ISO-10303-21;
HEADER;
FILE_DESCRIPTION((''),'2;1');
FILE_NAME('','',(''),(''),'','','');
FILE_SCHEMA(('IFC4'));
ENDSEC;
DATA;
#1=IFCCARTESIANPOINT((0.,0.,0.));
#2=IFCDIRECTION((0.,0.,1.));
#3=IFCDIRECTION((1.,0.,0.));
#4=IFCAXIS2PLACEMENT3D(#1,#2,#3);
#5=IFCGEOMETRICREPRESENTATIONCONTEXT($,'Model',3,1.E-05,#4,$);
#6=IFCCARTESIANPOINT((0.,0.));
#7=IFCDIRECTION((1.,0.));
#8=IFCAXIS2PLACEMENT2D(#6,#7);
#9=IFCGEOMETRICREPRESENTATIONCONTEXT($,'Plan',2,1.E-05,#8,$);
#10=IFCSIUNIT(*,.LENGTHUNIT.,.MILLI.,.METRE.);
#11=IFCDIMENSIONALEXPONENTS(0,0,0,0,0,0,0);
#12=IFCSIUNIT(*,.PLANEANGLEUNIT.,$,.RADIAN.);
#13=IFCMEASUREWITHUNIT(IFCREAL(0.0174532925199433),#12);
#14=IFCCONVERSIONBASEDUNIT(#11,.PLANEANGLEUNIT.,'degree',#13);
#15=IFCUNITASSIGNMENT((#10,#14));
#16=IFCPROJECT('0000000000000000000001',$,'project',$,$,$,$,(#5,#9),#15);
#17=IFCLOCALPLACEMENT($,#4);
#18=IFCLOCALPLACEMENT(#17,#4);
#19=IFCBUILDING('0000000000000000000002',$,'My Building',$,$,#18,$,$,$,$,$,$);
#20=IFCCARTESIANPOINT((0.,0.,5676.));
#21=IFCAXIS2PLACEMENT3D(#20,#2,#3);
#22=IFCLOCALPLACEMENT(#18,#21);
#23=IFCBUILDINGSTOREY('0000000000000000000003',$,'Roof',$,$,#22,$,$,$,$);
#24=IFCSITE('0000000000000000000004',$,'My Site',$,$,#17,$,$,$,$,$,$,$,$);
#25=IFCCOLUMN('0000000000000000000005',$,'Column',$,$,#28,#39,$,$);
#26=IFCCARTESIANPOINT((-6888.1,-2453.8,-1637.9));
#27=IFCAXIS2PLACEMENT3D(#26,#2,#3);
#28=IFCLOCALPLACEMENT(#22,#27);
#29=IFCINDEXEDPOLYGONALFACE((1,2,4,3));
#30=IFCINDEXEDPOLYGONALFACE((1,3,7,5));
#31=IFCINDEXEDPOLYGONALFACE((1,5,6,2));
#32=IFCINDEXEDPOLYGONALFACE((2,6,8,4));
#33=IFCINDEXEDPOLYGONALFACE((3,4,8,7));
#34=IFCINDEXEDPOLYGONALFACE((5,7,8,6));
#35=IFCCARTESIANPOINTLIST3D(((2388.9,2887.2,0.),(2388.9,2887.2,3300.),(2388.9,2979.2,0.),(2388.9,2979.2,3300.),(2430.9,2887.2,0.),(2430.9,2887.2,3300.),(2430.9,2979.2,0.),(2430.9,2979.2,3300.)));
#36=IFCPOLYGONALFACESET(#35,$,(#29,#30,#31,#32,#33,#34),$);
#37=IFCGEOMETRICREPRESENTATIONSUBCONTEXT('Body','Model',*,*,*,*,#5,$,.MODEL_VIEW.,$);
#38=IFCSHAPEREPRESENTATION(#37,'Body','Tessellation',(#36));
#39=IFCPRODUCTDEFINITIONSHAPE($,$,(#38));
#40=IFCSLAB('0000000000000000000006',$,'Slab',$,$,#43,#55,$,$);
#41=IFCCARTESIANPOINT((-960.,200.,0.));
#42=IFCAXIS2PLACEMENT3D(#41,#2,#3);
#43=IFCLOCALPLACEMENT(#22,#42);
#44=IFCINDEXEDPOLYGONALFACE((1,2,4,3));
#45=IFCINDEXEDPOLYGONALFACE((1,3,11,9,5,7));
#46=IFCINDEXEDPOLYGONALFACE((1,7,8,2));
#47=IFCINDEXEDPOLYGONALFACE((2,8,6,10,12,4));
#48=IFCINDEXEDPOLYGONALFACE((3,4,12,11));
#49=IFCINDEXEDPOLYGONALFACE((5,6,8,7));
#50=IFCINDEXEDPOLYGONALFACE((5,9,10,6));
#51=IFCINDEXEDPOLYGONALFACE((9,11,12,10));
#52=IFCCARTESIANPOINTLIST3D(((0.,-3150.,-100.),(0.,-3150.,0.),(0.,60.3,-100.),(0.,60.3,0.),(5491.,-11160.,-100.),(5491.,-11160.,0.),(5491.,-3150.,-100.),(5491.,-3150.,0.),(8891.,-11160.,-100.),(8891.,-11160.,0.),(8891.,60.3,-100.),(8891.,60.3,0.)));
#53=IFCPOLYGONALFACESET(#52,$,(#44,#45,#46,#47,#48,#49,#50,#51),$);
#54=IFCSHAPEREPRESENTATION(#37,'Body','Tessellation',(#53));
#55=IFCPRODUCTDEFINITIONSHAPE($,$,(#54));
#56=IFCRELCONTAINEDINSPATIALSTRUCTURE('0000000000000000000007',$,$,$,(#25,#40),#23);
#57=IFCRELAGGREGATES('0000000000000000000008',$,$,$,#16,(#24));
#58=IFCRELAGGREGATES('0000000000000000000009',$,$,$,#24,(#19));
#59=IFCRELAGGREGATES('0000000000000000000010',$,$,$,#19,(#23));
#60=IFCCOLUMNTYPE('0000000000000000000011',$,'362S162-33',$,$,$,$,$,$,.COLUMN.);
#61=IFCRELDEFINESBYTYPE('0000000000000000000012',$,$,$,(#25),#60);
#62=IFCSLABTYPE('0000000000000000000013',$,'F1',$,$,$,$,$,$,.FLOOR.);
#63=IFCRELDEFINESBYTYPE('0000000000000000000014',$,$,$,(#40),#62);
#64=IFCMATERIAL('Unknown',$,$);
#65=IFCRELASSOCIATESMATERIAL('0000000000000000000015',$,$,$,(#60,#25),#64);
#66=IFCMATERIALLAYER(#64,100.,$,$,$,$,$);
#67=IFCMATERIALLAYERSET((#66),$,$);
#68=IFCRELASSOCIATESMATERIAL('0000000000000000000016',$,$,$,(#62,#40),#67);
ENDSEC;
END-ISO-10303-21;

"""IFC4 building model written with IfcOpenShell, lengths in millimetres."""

from ifc_helpers import new_model, entity, si_unit, converted_unit, frame, origin_with_axes, origin_2d_with_axis, place, context, subcontext, project, spatial, indexed_curve, outline, extrude, material, layer, layer_set, layer_usage, material_profile, profile_set, profile_usage, type_object, element, save


model = new_model("IFC4")

# Units and contexts
model_context = context("Model", 3, precision=1e-05, world=origin_with_axes())
plan_context = context("Plan", 2, precision=1e-05, world=origin_2d_with_axis())
body_context = subcontext(model_context, "Body", "Model", "MODEL_VIEW")
ifc_project = project(units=[si_unit("LENGTHUNIT", "METRE", prefix="MILLI"), converted_unit("PLANEANGLEUNIT", "degree", entity("IfcReal", 0.0174532925199433), si_unit("PLANEANGLEUNIT", "RADIAN"), dimensions=[0, 0, 0, 0, 0, 0, 0])], contexts=[model_context, plan_context])

# Site, building, storey
site_placement = place(None, origin_with_axes())
site = spatial("IfcSite", under=ifc_project, at=site_placement, Name="My Site")
building_placement = place(site_placement, origin_with_axes())
building = spatial("IfcBuilding", under=site, at=building_placement, Name="My Building")
storey_placement = place(building_placement, frame((0.0, 0.0, 5676.0), z_axis=(0.0, 0.0, 1.0), x_axis=(1.0, 0.0, 0.0)))
storey = spatial("IfcBuildingStorey", under=building, at=storey_placement, Name="Roof")

# Column
ifc_material = material(Name="Unknown")
ifc_material_profile_1 = material_profile(ifc_material, outline(indexed_curve([(2430.9, 2887.2), (2388.9, 2887.2), (2388.9, 2979.2), (2430.9, 2979.2)])))
ifc_profile_set_1 = profile_set([ifc_material_profile_1])
ifc_profile_usage_1 = profile_usage(ifc_profile_set_1, cardinal=5)
column_type = type_object("IfcColumnType", Name="362S162-33", PredefinedType="COLUMN", material=ifc_profile_set_1)
column_placement = place(storey_placement, frame((-6888.1, -2453.8, -1637.9), z_axis=(0.0, 0.0, 1.0), x_axis=(1.0, 0.0, 0.0)))
element("IfcColumn", 1, at=column_placement, inside=storey, type_object=column_type, material=ifc_profile_usage_1, Name="Column", context=body_context, shape_type="SweptSolid", body=[
    extrude(outline(indexed_curve([(2430.9, 2887.2), (2388.9, 2887.2), (2388.9, 2979.2), (2430.9, 2979.2)])), origin_with_axes(), (0.0, 0.0, 1.0), 3300.0),
])

# Slab
ifc_layer = layer(ifc_material, 100.0)
ifc_layer_set = layer_set([ifc_layer])
ifc_layer_usage = layer_usage(ifc_layer_set, "AXIS3", "POSITIVE", -100.0)
slab_type = type_object("IfcSlabType", Name="F1", PredefinedType="FLOOR", material=ifc_layer_set)
slab_placement = place(storey_placement, frame((-960.0, 200.0, 0.0), z_axis=(0.0, 0.0, 1.0), x_axis=(1.0, 0.0, 0.0)))
element("IfcSlab", 2, at=slab_placement, inside=storey, type_object=slab_type, material=ifc_layer_usage, Name="Slab", context=body_context, shape_type="SweptSolid", body=[
    extrude(outline(indexed_curve([(0.0, 60.3), (8891.0, 60.3), (8891.0, -11160.0), (5491.0, -11160.0), (5491.0, -3150.0), (0.0, -3150.0), (0.0, 60.3)])), frame((0.0, 0.0, -100.0), z_axis=(0.0, 0.0, 1.0), x_axis=(1.0, 0.0, 0.0)), (0.0, 0.0, 1.0), 100.0),
])

save(model, "model.ifc")
